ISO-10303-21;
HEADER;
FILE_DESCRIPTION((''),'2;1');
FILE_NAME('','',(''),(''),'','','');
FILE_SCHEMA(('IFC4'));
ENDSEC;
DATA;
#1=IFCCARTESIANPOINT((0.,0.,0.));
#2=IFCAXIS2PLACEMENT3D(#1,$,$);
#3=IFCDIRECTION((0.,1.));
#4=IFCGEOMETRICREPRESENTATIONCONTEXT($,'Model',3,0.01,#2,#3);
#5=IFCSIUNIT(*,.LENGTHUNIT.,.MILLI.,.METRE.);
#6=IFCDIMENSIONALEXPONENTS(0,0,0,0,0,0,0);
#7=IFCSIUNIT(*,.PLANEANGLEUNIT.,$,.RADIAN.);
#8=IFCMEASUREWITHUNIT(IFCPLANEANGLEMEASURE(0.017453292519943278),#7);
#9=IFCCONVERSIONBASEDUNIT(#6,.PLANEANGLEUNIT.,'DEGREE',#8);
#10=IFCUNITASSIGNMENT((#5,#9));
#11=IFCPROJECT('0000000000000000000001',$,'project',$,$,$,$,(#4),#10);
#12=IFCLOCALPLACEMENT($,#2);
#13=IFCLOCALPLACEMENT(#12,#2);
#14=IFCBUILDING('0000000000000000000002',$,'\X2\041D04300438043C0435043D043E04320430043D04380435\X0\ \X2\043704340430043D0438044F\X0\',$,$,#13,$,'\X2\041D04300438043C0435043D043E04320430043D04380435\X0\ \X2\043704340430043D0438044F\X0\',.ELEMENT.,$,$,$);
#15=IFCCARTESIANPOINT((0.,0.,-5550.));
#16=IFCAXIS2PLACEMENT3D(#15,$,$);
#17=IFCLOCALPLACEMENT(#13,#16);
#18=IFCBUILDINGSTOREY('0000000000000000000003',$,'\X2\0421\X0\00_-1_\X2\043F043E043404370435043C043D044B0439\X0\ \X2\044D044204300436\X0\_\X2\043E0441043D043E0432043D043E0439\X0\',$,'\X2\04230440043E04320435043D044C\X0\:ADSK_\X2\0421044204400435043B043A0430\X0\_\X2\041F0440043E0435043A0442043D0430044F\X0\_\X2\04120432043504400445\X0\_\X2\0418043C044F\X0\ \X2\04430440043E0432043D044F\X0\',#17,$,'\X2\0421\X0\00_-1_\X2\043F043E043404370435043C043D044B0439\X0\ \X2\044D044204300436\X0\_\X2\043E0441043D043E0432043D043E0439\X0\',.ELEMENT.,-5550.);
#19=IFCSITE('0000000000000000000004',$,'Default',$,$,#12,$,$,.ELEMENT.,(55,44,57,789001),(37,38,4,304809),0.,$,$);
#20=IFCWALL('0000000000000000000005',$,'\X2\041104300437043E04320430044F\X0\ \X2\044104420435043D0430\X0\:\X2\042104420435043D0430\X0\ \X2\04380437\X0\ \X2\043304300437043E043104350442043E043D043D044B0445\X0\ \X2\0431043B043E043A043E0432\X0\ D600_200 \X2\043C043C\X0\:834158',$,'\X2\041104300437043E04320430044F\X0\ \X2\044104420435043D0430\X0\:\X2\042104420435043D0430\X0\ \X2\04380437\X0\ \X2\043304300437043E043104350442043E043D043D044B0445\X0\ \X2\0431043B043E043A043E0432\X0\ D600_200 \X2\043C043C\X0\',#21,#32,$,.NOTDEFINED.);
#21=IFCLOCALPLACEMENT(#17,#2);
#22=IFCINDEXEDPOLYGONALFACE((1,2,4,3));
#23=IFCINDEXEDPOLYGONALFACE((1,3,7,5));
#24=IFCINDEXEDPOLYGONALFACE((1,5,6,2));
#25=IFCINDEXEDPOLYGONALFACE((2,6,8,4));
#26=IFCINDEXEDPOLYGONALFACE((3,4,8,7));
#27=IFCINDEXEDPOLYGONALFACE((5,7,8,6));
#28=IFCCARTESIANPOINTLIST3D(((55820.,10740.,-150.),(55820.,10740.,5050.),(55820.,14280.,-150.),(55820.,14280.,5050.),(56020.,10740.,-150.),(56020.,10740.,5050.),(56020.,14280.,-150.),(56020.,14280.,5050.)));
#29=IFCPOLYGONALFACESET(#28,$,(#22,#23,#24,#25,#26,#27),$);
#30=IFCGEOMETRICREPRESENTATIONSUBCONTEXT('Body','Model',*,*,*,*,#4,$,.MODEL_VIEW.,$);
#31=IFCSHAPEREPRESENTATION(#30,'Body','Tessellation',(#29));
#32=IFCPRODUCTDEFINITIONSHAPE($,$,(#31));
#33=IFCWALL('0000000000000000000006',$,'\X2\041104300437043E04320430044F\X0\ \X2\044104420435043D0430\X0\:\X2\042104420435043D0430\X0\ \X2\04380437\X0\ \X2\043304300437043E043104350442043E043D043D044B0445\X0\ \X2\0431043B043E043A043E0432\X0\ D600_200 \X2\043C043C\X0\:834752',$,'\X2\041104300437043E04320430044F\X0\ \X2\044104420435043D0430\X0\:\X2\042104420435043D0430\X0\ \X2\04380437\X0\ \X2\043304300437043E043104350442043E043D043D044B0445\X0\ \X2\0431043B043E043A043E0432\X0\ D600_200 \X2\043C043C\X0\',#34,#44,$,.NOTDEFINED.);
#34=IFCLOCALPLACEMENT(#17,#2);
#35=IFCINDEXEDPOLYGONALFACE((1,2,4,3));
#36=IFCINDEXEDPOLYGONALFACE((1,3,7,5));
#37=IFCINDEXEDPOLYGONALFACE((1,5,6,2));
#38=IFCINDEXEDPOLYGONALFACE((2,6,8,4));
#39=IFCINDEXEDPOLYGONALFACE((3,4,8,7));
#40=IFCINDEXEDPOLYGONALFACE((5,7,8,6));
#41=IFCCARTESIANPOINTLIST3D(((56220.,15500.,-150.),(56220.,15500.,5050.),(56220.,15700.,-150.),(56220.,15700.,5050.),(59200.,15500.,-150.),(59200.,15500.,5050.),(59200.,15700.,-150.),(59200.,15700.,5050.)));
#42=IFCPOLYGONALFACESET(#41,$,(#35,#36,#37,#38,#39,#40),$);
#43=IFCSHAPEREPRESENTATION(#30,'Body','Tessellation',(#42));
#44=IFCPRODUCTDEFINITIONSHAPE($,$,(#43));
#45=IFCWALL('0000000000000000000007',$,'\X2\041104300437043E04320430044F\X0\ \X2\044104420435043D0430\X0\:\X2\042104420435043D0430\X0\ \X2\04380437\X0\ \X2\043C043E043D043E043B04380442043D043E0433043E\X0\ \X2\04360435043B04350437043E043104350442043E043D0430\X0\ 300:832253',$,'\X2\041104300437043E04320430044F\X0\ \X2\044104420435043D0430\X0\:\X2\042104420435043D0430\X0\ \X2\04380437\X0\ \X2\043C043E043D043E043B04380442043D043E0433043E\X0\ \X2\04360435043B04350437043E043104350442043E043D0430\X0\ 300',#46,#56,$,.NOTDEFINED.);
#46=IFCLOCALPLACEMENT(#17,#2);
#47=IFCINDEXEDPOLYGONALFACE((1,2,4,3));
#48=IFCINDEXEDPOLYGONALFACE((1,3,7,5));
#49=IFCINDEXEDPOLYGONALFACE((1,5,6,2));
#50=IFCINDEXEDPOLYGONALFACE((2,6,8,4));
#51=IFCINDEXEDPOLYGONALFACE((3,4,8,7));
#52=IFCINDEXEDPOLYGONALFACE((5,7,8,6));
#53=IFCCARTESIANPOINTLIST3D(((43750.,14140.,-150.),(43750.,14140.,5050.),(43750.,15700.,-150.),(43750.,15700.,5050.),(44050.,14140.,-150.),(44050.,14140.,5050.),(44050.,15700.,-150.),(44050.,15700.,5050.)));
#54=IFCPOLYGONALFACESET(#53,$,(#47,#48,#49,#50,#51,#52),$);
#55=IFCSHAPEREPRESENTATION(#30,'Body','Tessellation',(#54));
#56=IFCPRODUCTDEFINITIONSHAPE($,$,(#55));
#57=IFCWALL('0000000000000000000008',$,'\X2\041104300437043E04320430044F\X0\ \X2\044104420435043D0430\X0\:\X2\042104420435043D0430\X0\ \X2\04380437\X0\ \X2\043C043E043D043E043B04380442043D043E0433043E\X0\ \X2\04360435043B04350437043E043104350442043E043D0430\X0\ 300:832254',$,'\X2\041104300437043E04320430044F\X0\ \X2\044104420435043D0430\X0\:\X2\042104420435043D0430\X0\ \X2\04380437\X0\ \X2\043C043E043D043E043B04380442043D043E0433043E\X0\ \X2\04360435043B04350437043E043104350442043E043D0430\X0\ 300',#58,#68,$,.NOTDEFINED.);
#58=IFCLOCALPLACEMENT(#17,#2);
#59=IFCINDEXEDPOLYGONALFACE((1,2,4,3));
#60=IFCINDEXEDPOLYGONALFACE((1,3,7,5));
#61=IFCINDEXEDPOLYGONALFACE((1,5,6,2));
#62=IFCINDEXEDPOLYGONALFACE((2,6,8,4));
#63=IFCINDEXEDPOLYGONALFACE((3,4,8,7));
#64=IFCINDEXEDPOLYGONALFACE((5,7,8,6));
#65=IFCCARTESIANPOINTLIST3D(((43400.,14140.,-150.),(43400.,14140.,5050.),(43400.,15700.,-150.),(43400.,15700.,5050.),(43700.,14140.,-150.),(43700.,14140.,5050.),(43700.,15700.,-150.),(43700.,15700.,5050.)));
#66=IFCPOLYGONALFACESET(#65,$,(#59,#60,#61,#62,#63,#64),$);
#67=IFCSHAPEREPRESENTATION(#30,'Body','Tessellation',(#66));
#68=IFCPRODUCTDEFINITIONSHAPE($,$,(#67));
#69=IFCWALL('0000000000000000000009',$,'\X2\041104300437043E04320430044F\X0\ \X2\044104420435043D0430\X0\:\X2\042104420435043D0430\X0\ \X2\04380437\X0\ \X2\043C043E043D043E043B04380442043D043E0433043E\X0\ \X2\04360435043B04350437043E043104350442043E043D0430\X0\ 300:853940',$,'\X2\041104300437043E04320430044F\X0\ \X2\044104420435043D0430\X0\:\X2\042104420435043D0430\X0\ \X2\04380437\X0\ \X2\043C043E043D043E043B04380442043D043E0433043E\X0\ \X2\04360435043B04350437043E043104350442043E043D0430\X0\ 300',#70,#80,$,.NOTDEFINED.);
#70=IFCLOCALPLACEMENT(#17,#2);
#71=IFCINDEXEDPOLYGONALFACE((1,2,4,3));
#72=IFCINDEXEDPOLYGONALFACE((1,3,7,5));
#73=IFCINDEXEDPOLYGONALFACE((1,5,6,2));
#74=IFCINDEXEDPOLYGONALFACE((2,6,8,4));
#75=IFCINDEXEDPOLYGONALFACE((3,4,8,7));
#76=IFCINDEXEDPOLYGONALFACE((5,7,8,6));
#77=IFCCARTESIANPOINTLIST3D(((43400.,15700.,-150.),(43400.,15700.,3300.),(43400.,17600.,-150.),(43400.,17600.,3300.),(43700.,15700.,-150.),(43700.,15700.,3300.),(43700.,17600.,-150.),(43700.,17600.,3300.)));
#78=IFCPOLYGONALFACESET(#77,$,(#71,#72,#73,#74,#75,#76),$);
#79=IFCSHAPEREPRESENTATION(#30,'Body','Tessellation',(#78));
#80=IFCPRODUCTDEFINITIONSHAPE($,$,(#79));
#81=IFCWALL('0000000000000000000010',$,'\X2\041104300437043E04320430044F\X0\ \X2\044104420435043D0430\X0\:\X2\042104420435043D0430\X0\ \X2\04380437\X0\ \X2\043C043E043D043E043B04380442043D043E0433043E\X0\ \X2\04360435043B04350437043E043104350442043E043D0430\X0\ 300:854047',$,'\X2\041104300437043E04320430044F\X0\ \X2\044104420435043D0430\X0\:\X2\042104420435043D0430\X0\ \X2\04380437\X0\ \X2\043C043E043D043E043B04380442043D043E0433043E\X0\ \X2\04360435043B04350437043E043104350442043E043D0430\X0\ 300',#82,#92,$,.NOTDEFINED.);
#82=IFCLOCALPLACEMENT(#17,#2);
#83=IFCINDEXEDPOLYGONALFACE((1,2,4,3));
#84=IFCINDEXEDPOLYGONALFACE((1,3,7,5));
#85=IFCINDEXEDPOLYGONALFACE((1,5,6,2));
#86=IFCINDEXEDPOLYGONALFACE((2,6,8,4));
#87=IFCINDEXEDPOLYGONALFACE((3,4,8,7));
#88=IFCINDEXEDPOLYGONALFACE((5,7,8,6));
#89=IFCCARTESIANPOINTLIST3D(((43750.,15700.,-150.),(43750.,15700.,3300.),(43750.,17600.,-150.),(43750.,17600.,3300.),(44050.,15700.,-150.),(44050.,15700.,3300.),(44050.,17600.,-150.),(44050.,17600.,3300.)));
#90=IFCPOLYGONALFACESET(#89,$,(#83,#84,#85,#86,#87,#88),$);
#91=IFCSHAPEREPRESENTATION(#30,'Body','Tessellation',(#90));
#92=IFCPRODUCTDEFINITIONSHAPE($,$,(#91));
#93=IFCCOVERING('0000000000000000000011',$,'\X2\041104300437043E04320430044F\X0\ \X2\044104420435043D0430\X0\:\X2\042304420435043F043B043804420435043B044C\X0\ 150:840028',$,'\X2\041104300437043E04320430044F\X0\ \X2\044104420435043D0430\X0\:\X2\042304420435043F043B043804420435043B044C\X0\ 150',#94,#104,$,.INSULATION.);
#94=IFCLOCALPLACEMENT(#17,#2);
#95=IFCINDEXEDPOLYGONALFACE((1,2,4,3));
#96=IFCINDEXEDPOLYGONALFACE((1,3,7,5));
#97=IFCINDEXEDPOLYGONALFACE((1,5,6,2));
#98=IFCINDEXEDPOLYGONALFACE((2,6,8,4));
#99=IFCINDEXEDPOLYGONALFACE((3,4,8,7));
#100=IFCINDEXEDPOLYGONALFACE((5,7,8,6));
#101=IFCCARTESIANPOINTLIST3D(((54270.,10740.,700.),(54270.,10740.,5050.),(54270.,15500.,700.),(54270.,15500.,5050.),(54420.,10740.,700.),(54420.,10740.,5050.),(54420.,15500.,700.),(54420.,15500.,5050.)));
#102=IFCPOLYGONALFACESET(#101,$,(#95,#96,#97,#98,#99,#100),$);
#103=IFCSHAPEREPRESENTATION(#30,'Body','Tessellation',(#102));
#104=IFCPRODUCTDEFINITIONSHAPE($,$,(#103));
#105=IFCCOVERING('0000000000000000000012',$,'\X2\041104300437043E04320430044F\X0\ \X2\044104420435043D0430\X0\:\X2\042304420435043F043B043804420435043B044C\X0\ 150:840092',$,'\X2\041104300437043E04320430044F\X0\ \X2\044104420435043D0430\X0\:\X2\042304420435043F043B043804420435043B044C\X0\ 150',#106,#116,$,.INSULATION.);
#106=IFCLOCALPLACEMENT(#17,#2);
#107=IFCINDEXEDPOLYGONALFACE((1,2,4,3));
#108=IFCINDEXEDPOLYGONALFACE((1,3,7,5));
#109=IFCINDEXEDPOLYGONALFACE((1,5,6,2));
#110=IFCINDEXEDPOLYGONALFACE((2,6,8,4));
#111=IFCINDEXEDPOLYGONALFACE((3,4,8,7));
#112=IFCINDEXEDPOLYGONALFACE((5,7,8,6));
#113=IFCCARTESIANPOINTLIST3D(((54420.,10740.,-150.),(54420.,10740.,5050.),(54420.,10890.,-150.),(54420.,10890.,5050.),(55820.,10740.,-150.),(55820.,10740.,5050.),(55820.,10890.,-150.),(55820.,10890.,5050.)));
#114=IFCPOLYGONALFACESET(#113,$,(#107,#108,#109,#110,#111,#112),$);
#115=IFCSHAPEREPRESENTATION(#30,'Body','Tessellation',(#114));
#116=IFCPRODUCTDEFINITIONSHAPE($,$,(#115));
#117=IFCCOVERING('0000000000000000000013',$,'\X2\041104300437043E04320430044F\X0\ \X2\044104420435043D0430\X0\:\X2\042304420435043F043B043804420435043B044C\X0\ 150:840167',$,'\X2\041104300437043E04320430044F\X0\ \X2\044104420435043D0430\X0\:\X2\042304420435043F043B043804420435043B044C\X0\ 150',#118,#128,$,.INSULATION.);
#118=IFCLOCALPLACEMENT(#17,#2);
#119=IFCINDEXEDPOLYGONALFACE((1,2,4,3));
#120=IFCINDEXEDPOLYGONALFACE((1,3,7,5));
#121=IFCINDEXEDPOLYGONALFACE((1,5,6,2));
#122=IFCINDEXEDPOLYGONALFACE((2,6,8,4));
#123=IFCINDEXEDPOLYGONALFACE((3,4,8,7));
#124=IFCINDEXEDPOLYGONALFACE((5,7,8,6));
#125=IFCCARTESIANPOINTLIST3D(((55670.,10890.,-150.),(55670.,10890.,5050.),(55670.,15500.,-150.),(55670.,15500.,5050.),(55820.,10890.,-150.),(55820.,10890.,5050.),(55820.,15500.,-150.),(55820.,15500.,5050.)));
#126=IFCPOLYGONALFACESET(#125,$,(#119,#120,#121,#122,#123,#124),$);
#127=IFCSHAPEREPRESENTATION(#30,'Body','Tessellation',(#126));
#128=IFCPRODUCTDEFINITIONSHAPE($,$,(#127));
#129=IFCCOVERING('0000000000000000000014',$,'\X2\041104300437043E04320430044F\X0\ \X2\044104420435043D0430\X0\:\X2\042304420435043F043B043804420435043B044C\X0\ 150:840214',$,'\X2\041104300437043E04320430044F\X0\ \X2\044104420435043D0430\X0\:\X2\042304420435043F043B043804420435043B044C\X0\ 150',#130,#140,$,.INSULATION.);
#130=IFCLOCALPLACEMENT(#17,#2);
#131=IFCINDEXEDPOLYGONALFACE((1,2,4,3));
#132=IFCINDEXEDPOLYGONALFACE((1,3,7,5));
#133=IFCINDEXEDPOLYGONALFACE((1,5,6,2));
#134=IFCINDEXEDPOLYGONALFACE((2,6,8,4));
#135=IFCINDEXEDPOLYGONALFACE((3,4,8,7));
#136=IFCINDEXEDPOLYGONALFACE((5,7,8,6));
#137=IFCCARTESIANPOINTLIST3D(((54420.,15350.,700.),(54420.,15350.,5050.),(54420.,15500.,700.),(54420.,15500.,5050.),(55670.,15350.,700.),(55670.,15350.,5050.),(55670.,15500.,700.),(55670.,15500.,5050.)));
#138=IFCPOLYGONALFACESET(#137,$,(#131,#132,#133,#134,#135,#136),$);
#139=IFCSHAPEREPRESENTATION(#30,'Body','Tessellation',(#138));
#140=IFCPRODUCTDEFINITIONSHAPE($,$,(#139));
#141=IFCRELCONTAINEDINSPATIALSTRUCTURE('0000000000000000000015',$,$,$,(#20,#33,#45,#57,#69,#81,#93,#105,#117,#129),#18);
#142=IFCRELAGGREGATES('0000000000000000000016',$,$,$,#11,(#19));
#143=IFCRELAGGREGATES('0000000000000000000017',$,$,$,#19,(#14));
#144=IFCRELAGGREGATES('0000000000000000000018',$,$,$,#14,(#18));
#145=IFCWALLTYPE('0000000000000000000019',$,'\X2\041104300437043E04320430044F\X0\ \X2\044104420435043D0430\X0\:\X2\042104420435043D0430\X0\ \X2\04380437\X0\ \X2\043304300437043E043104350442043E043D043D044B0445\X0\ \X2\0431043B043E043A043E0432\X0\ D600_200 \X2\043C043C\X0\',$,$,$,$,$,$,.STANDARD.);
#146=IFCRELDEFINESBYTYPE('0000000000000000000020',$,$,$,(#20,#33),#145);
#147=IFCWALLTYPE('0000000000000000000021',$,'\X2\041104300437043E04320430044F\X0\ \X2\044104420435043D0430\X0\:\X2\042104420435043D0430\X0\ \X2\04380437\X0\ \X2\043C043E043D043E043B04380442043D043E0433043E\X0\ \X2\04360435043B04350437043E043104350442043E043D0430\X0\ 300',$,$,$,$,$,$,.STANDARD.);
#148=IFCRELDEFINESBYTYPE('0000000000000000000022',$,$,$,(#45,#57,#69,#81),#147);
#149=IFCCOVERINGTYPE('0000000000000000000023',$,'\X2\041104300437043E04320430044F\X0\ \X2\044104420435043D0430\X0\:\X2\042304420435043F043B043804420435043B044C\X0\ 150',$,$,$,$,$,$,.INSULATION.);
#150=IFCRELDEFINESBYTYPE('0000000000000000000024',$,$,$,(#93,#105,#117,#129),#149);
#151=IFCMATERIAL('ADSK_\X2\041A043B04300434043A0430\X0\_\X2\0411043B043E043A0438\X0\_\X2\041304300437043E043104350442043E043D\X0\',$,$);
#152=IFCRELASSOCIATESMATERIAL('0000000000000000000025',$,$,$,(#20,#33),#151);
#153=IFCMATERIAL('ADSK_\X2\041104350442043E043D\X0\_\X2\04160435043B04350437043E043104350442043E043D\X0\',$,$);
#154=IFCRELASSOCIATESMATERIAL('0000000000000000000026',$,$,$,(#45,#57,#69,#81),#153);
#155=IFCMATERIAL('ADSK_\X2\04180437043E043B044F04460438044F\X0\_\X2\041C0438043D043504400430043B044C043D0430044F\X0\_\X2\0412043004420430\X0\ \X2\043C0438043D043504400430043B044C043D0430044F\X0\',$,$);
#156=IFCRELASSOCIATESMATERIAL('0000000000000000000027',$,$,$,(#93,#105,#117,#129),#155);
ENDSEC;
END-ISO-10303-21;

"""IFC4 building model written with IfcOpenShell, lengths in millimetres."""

from ifc_helpers import new_model, entity, si_unit, converted_unit, direction, frame, origin, place, context, subcontext, project, spatial, indexed_curve, outline, extrude, material, type_object, element, save


model = new_model("IFC4")

# Units and contexts
model_context = context("Model", 3, precision=0.01, world=origin(), true_north=direction((0.0, 1.0)))
body_context = subcontext(model_context, "Body", "Model", "MODEL_VIEW")
ifc_project = project(units=[si_unit("LENGTHUNIT", "METRE", prefix="MILLI"), converted_unit("PLANEANGLEUNIT", "DEGREE", entity("IfcPlaneAngleMeasure", 0.017453292519943278), si_unit("PLANEANGLEUNIT", "RADIAN"), dimensions=[0, 0, 0, 0, 0, 0, 0])], contexts=[model_context])

# Site, building, storey
site_placement = place(None, origin())
site = spatial("IfcSite", under=ifc_project, at=site_placement, Name="Default", CompositionType="ELEMENT", RefLatitude=(55, 44, 57, 789001), RefLongitude=(37, 38, 4, 304809), RefElevation=0.0)
building_placement = place(site_placement, origin())
building = spatial("IfcBuilding", under=site, at=building_placement, Name="Наименование здания", LongName="Наименование здания", CompositionType="ELEMENT")
storey_placement = place(building_placement, frame((0.0, 0.0, -5550.0)))
storey = spatial("IfcBuildingStorey", under=building, at=storey_placement, Name="С00_-1_подземный этаж_основной", ObjectType="Уровень:ADSK_Стрелка_Проектная_Вверх_Имя уровня", LongName="С00_-1_подземный этаж_основной", CompositionType="ELEMENT", Elevation=-5550.0)

# Shared definitions
ifc_material_1 = material(Name="ADSK_Бетон_Железобетон")

# Walls
ifc_material_2 = material(Name="ADSK_Кладка_Блоки_Газобетон")
wall_type_1 = type_object("IfcWallType", Name="Базовая стена:Стена из газобетонных блоков D600_200 мм", PredefinedType="STANDARD")
wall_1_placement = place(storey_placement, frame((55920.0, 14280.0, -150.0), z_axis=(0.0, 0.0, 1.0), x_axis=(0.0, -1.0, 0.0)))
element("IfcWall", 1, at=wall_1_placement, inside=storey, type_object=wall_type_1, material=ifc_material_2, Name="Базовая стена:Стена из газобетонных блоков D600_200 мм:834158", ObjectType="Базовая стена:Стена из газобетонных блоков D600_200 мм", PredefinedType="NOTDEFINED", context=body_context, shape_type="SweptSolid", body=[
    extrude(outline(indexed_curve([(3540.0, 100.0), (0.0, 100.0), (0.0, -100.0), (3540.0, -100.0), (3540.0, 100.0)], self_intersect=False)), origin(), (0.0, 0.0, 1.0), 5200.0),
])
wall_2_placement = place(storey_placement, frame((56220.0, 15600.0, -150.0)))
element("IfcWall", 2, at=wall_2_placement, inside=storey, type_object=wall_type_1, material=ifc_material_2, Name="Базовая стена:Стена из газобетонных блоков D600_200 мм:834752", ObjectType="Базовая стена:Стена из газобетонных блоков D600_200 мм", PredefinedType="NOTDEFINED", context=body_context, shape_type="SweptSolid", body=[
    extrude(outline(indexed_curve([(2980.0, 100.0), (0.0, 100.0), (0.0, -100.0), (2980.0, -100.0), (2980.0, 100.0)], self_intersect=False)), origin(), (0.0, 0.0, 1.0), 5200.0),
])
wall_type_2 = type_object("IfcWallType", Name="Базовая стена:Стена из монолитного железобетона 300", PredefinedType="STANDARD")
wall_3_placement = place(storey_placement, frame((43900.0, 14140.0, -150.0), z_axis=(0.0, 0.0, 1.0), x_axis=(0.0, 1.0, 0.0)))
element("IfcWall", 3, at=wall_3_placement, inside=storey, type_object=wall_type_2, material=ifc_material_1, Name="Базовая стена:Стена из монолитного железобетона 300:832253", ObjectType="Базовая стена:Стена из монолитного железобетона 300", PredefinedType="NOTDEFINED", context=body_context, shape_type="SweptSolid", body=[
    extrude(outline(indexed_curve([(1560.0, 150.0), (0.0, 150.0), (0.0, -150.0), (1560.0, -150.0), (1560.0, 150.0)], self_intersect=False)), origin(), (0.0, 0.0, 1.0), 5200.0),
])
wall_4_placement = place(storey_placement, frame((43550.0, 14140.0, -150.0), z_axis=(0.0, 0.0, 1.0), x_axis=(0.0, 1.0, 0.0)))
element("IfcWall", 4, at=wall_4_placement, inside=storey, type_object=wall_type_2, material=ifc_material_1, Name="Базовая стена:Стена из монолитного железобетона 300:832254", ObjectType="Базовая стена:Стена из монолитного железобетона 300", PredefinedType="NOTDEFINED", context=body_context, shape_type="SweptSolid", body=[
    extrude(outline(indexed_curve([(1560.0, 150.0), (0.0, 150.0), (0.0, -150.0), (1560.0, -150.0), (1560.0, 150.0)], self_intersect=False)), origin(), (0.0, 0.0, 1.0), 5200.0),
])
wall_5_placement = place(storey_placement, frame((43550.0, 15700.0, -150.0), z_axis=(0.0, 0.0, 1.0), x_axis=(0.0, 1.0, 0.0)))
element("IfcWall", 5, at=wall_5_placement, inside=storey, type_object=wall_type_2, material=ifc_material_1, Name="Базовая стена:Стена из монолитного железобетона 300:853940", ObjectType="Базовая стена:Стена из монолитного железобетона 300", PredefinedType="NOTDEFINED", context=body_context, shape_type="SweptSolid", body=[
    extrude(outline(indexed_curve([(1900.0, 150.0), (0.0, 150.0), (0.0, -150.0), (1900.0, -150.0), (1900.0, 150.0)], self_intersect=False)), origin(), (0.0, 0.0, 1.0), 3450.0),
])
wall_6_placement = place(storey_placement, frame((43900.0, 15700.0, -150.0), z_axis=(0.0, 0.0, 1.0), x_axis=(0.0, 1.0, 0.0)))
element("IfcWall", 6, at=wall_6_placement, inside=storey, type_object=wall_type_2, material=ifc_material_1, Name="Базовая стена:Стена из монолитного железобетона 300:854047", ObjectType="Базовая стена:Стена из монолитного железобетона 300", PredefinedType="NOTDEFINED", context=body_context, shape_type="SweptSolid", body=[
    extrude(outline(indexed_curve([(1900.0, 150.0), (0.0, 150.0), (0.0, -150.0), (1900.0, -150.0), (1900.0, 150.0)], self_intersect=False)), origin(), (0.0, 0.0, 1.0), 3450.0),
])

# Coverings
ifc_material_3 = material(Name="ADSK_Изоляция_Минеральная_Вата минеральная")
covering_type = type_object("IfcCoveringType", Name="Базовая стена:Утеплитель 150", PredefinedType="INSULATION")
covering_1_placement = place(storey_placement, frame((54345.0, 15500.0, 700.0), z_axis=(0.0, 0.0, 1.0), x_axis=(0.0, -1.0, 0.0)))
element("IfcCovering", 7, at=covering_1_placement, inside=storey, type_object=covering_type, material=ifc_material_3, Name="Базовая стена:Утеплитель 150:840028", ObjectType="Базовая стена:Утеплитель 150", PredefinedType="INSULATION", context=body_context, shape_type="SweptSolid", body=[
    extrude(outline(indexed_curve([(4760.0, 75.0), (0.0, 75.0), (0.0, -75.0), (4760.0, -75.0), (4760.0, 75.0)], self_intersect=False)), origin(), (0.0, 0.0, 1.0), 4350.0),
])
covering_2_placement = place(storey_placement, frame((54420.0, 10815.0, -150.0)))
element("IfcCovering", 8, at=covering_2_placement, inside=storey, type_object=covering_type, material=ifc_material_3, Name="Базовая стена:Утеплитель 150:840092", ObjectType="Базовая стена:Утеплитель 150", PredefinedType="INSULATION", context=body_context, shape_type="SweptSolid", body=[
    extrude(outline(indexed_curve([(1400.0, 75.0), (0.0, 75.0), (0.0, -75.0), (1400.0, -75.0), (1400.0, 75.0)], self_intersect=False)), origin(), (0.0, 0.0, 1.0), 5200.0),
])
covering_3_placement = place(storey_placement, frame((55745.0, 10890.0, -150.0), z_axis=(0.0, 0.0, 1.0), x_axis=(0.0, 1.0, 0.0)))
element("IfcCovering", 9, at=covering_3_placement, inside=storey, type_object=covering_type, material=ifc_material_3, Name="Базовая стена:Утеплитель 150:840167", ObjectType="Базовая стена:Утеплитель 150", PredefinedType="INSULATION", context=body_context, shape_type="SweptSolid", body=[
    extrude(outline(indexed_curve([(4610.0, 75.0), (0.0, 75.0), (0.0, -75.0), (4610.0, -75.0), (4610.0, 75.0)], self_intersect=False)), origin(), (0.0, 0.0, 1.0), 5200.0),
])
covering_4_placement = place(storey_placement, frame((55670.0, 15425.0, 700.0), z_axis=(0.0, 0.0, 1.0), x_axis=(-1.0, 0.0, 0.0)))
element("IfcCovering", 10, at=covering_4_placement, inside=storey, type_object=covering_type, material=ifc_material_3, Name="Базовая стена:Утеплитель 150:840214", ObjectType="Базовая стена:Утеплитель 150", PredefinedType="INSULATION", context=body_context, shape_type="SweptSolid", body=[
    extrude(outline(indexed_curve([(1250.0, 75.0), (0.0, 75.0), (0.0, -75.0), (1250.0, -75.0), (1250.0, 75.0)], self_intersect=False)), origin(), (0.0, 0.0, 1.0), 4350.0),
])

save(model, "model.ifc")
